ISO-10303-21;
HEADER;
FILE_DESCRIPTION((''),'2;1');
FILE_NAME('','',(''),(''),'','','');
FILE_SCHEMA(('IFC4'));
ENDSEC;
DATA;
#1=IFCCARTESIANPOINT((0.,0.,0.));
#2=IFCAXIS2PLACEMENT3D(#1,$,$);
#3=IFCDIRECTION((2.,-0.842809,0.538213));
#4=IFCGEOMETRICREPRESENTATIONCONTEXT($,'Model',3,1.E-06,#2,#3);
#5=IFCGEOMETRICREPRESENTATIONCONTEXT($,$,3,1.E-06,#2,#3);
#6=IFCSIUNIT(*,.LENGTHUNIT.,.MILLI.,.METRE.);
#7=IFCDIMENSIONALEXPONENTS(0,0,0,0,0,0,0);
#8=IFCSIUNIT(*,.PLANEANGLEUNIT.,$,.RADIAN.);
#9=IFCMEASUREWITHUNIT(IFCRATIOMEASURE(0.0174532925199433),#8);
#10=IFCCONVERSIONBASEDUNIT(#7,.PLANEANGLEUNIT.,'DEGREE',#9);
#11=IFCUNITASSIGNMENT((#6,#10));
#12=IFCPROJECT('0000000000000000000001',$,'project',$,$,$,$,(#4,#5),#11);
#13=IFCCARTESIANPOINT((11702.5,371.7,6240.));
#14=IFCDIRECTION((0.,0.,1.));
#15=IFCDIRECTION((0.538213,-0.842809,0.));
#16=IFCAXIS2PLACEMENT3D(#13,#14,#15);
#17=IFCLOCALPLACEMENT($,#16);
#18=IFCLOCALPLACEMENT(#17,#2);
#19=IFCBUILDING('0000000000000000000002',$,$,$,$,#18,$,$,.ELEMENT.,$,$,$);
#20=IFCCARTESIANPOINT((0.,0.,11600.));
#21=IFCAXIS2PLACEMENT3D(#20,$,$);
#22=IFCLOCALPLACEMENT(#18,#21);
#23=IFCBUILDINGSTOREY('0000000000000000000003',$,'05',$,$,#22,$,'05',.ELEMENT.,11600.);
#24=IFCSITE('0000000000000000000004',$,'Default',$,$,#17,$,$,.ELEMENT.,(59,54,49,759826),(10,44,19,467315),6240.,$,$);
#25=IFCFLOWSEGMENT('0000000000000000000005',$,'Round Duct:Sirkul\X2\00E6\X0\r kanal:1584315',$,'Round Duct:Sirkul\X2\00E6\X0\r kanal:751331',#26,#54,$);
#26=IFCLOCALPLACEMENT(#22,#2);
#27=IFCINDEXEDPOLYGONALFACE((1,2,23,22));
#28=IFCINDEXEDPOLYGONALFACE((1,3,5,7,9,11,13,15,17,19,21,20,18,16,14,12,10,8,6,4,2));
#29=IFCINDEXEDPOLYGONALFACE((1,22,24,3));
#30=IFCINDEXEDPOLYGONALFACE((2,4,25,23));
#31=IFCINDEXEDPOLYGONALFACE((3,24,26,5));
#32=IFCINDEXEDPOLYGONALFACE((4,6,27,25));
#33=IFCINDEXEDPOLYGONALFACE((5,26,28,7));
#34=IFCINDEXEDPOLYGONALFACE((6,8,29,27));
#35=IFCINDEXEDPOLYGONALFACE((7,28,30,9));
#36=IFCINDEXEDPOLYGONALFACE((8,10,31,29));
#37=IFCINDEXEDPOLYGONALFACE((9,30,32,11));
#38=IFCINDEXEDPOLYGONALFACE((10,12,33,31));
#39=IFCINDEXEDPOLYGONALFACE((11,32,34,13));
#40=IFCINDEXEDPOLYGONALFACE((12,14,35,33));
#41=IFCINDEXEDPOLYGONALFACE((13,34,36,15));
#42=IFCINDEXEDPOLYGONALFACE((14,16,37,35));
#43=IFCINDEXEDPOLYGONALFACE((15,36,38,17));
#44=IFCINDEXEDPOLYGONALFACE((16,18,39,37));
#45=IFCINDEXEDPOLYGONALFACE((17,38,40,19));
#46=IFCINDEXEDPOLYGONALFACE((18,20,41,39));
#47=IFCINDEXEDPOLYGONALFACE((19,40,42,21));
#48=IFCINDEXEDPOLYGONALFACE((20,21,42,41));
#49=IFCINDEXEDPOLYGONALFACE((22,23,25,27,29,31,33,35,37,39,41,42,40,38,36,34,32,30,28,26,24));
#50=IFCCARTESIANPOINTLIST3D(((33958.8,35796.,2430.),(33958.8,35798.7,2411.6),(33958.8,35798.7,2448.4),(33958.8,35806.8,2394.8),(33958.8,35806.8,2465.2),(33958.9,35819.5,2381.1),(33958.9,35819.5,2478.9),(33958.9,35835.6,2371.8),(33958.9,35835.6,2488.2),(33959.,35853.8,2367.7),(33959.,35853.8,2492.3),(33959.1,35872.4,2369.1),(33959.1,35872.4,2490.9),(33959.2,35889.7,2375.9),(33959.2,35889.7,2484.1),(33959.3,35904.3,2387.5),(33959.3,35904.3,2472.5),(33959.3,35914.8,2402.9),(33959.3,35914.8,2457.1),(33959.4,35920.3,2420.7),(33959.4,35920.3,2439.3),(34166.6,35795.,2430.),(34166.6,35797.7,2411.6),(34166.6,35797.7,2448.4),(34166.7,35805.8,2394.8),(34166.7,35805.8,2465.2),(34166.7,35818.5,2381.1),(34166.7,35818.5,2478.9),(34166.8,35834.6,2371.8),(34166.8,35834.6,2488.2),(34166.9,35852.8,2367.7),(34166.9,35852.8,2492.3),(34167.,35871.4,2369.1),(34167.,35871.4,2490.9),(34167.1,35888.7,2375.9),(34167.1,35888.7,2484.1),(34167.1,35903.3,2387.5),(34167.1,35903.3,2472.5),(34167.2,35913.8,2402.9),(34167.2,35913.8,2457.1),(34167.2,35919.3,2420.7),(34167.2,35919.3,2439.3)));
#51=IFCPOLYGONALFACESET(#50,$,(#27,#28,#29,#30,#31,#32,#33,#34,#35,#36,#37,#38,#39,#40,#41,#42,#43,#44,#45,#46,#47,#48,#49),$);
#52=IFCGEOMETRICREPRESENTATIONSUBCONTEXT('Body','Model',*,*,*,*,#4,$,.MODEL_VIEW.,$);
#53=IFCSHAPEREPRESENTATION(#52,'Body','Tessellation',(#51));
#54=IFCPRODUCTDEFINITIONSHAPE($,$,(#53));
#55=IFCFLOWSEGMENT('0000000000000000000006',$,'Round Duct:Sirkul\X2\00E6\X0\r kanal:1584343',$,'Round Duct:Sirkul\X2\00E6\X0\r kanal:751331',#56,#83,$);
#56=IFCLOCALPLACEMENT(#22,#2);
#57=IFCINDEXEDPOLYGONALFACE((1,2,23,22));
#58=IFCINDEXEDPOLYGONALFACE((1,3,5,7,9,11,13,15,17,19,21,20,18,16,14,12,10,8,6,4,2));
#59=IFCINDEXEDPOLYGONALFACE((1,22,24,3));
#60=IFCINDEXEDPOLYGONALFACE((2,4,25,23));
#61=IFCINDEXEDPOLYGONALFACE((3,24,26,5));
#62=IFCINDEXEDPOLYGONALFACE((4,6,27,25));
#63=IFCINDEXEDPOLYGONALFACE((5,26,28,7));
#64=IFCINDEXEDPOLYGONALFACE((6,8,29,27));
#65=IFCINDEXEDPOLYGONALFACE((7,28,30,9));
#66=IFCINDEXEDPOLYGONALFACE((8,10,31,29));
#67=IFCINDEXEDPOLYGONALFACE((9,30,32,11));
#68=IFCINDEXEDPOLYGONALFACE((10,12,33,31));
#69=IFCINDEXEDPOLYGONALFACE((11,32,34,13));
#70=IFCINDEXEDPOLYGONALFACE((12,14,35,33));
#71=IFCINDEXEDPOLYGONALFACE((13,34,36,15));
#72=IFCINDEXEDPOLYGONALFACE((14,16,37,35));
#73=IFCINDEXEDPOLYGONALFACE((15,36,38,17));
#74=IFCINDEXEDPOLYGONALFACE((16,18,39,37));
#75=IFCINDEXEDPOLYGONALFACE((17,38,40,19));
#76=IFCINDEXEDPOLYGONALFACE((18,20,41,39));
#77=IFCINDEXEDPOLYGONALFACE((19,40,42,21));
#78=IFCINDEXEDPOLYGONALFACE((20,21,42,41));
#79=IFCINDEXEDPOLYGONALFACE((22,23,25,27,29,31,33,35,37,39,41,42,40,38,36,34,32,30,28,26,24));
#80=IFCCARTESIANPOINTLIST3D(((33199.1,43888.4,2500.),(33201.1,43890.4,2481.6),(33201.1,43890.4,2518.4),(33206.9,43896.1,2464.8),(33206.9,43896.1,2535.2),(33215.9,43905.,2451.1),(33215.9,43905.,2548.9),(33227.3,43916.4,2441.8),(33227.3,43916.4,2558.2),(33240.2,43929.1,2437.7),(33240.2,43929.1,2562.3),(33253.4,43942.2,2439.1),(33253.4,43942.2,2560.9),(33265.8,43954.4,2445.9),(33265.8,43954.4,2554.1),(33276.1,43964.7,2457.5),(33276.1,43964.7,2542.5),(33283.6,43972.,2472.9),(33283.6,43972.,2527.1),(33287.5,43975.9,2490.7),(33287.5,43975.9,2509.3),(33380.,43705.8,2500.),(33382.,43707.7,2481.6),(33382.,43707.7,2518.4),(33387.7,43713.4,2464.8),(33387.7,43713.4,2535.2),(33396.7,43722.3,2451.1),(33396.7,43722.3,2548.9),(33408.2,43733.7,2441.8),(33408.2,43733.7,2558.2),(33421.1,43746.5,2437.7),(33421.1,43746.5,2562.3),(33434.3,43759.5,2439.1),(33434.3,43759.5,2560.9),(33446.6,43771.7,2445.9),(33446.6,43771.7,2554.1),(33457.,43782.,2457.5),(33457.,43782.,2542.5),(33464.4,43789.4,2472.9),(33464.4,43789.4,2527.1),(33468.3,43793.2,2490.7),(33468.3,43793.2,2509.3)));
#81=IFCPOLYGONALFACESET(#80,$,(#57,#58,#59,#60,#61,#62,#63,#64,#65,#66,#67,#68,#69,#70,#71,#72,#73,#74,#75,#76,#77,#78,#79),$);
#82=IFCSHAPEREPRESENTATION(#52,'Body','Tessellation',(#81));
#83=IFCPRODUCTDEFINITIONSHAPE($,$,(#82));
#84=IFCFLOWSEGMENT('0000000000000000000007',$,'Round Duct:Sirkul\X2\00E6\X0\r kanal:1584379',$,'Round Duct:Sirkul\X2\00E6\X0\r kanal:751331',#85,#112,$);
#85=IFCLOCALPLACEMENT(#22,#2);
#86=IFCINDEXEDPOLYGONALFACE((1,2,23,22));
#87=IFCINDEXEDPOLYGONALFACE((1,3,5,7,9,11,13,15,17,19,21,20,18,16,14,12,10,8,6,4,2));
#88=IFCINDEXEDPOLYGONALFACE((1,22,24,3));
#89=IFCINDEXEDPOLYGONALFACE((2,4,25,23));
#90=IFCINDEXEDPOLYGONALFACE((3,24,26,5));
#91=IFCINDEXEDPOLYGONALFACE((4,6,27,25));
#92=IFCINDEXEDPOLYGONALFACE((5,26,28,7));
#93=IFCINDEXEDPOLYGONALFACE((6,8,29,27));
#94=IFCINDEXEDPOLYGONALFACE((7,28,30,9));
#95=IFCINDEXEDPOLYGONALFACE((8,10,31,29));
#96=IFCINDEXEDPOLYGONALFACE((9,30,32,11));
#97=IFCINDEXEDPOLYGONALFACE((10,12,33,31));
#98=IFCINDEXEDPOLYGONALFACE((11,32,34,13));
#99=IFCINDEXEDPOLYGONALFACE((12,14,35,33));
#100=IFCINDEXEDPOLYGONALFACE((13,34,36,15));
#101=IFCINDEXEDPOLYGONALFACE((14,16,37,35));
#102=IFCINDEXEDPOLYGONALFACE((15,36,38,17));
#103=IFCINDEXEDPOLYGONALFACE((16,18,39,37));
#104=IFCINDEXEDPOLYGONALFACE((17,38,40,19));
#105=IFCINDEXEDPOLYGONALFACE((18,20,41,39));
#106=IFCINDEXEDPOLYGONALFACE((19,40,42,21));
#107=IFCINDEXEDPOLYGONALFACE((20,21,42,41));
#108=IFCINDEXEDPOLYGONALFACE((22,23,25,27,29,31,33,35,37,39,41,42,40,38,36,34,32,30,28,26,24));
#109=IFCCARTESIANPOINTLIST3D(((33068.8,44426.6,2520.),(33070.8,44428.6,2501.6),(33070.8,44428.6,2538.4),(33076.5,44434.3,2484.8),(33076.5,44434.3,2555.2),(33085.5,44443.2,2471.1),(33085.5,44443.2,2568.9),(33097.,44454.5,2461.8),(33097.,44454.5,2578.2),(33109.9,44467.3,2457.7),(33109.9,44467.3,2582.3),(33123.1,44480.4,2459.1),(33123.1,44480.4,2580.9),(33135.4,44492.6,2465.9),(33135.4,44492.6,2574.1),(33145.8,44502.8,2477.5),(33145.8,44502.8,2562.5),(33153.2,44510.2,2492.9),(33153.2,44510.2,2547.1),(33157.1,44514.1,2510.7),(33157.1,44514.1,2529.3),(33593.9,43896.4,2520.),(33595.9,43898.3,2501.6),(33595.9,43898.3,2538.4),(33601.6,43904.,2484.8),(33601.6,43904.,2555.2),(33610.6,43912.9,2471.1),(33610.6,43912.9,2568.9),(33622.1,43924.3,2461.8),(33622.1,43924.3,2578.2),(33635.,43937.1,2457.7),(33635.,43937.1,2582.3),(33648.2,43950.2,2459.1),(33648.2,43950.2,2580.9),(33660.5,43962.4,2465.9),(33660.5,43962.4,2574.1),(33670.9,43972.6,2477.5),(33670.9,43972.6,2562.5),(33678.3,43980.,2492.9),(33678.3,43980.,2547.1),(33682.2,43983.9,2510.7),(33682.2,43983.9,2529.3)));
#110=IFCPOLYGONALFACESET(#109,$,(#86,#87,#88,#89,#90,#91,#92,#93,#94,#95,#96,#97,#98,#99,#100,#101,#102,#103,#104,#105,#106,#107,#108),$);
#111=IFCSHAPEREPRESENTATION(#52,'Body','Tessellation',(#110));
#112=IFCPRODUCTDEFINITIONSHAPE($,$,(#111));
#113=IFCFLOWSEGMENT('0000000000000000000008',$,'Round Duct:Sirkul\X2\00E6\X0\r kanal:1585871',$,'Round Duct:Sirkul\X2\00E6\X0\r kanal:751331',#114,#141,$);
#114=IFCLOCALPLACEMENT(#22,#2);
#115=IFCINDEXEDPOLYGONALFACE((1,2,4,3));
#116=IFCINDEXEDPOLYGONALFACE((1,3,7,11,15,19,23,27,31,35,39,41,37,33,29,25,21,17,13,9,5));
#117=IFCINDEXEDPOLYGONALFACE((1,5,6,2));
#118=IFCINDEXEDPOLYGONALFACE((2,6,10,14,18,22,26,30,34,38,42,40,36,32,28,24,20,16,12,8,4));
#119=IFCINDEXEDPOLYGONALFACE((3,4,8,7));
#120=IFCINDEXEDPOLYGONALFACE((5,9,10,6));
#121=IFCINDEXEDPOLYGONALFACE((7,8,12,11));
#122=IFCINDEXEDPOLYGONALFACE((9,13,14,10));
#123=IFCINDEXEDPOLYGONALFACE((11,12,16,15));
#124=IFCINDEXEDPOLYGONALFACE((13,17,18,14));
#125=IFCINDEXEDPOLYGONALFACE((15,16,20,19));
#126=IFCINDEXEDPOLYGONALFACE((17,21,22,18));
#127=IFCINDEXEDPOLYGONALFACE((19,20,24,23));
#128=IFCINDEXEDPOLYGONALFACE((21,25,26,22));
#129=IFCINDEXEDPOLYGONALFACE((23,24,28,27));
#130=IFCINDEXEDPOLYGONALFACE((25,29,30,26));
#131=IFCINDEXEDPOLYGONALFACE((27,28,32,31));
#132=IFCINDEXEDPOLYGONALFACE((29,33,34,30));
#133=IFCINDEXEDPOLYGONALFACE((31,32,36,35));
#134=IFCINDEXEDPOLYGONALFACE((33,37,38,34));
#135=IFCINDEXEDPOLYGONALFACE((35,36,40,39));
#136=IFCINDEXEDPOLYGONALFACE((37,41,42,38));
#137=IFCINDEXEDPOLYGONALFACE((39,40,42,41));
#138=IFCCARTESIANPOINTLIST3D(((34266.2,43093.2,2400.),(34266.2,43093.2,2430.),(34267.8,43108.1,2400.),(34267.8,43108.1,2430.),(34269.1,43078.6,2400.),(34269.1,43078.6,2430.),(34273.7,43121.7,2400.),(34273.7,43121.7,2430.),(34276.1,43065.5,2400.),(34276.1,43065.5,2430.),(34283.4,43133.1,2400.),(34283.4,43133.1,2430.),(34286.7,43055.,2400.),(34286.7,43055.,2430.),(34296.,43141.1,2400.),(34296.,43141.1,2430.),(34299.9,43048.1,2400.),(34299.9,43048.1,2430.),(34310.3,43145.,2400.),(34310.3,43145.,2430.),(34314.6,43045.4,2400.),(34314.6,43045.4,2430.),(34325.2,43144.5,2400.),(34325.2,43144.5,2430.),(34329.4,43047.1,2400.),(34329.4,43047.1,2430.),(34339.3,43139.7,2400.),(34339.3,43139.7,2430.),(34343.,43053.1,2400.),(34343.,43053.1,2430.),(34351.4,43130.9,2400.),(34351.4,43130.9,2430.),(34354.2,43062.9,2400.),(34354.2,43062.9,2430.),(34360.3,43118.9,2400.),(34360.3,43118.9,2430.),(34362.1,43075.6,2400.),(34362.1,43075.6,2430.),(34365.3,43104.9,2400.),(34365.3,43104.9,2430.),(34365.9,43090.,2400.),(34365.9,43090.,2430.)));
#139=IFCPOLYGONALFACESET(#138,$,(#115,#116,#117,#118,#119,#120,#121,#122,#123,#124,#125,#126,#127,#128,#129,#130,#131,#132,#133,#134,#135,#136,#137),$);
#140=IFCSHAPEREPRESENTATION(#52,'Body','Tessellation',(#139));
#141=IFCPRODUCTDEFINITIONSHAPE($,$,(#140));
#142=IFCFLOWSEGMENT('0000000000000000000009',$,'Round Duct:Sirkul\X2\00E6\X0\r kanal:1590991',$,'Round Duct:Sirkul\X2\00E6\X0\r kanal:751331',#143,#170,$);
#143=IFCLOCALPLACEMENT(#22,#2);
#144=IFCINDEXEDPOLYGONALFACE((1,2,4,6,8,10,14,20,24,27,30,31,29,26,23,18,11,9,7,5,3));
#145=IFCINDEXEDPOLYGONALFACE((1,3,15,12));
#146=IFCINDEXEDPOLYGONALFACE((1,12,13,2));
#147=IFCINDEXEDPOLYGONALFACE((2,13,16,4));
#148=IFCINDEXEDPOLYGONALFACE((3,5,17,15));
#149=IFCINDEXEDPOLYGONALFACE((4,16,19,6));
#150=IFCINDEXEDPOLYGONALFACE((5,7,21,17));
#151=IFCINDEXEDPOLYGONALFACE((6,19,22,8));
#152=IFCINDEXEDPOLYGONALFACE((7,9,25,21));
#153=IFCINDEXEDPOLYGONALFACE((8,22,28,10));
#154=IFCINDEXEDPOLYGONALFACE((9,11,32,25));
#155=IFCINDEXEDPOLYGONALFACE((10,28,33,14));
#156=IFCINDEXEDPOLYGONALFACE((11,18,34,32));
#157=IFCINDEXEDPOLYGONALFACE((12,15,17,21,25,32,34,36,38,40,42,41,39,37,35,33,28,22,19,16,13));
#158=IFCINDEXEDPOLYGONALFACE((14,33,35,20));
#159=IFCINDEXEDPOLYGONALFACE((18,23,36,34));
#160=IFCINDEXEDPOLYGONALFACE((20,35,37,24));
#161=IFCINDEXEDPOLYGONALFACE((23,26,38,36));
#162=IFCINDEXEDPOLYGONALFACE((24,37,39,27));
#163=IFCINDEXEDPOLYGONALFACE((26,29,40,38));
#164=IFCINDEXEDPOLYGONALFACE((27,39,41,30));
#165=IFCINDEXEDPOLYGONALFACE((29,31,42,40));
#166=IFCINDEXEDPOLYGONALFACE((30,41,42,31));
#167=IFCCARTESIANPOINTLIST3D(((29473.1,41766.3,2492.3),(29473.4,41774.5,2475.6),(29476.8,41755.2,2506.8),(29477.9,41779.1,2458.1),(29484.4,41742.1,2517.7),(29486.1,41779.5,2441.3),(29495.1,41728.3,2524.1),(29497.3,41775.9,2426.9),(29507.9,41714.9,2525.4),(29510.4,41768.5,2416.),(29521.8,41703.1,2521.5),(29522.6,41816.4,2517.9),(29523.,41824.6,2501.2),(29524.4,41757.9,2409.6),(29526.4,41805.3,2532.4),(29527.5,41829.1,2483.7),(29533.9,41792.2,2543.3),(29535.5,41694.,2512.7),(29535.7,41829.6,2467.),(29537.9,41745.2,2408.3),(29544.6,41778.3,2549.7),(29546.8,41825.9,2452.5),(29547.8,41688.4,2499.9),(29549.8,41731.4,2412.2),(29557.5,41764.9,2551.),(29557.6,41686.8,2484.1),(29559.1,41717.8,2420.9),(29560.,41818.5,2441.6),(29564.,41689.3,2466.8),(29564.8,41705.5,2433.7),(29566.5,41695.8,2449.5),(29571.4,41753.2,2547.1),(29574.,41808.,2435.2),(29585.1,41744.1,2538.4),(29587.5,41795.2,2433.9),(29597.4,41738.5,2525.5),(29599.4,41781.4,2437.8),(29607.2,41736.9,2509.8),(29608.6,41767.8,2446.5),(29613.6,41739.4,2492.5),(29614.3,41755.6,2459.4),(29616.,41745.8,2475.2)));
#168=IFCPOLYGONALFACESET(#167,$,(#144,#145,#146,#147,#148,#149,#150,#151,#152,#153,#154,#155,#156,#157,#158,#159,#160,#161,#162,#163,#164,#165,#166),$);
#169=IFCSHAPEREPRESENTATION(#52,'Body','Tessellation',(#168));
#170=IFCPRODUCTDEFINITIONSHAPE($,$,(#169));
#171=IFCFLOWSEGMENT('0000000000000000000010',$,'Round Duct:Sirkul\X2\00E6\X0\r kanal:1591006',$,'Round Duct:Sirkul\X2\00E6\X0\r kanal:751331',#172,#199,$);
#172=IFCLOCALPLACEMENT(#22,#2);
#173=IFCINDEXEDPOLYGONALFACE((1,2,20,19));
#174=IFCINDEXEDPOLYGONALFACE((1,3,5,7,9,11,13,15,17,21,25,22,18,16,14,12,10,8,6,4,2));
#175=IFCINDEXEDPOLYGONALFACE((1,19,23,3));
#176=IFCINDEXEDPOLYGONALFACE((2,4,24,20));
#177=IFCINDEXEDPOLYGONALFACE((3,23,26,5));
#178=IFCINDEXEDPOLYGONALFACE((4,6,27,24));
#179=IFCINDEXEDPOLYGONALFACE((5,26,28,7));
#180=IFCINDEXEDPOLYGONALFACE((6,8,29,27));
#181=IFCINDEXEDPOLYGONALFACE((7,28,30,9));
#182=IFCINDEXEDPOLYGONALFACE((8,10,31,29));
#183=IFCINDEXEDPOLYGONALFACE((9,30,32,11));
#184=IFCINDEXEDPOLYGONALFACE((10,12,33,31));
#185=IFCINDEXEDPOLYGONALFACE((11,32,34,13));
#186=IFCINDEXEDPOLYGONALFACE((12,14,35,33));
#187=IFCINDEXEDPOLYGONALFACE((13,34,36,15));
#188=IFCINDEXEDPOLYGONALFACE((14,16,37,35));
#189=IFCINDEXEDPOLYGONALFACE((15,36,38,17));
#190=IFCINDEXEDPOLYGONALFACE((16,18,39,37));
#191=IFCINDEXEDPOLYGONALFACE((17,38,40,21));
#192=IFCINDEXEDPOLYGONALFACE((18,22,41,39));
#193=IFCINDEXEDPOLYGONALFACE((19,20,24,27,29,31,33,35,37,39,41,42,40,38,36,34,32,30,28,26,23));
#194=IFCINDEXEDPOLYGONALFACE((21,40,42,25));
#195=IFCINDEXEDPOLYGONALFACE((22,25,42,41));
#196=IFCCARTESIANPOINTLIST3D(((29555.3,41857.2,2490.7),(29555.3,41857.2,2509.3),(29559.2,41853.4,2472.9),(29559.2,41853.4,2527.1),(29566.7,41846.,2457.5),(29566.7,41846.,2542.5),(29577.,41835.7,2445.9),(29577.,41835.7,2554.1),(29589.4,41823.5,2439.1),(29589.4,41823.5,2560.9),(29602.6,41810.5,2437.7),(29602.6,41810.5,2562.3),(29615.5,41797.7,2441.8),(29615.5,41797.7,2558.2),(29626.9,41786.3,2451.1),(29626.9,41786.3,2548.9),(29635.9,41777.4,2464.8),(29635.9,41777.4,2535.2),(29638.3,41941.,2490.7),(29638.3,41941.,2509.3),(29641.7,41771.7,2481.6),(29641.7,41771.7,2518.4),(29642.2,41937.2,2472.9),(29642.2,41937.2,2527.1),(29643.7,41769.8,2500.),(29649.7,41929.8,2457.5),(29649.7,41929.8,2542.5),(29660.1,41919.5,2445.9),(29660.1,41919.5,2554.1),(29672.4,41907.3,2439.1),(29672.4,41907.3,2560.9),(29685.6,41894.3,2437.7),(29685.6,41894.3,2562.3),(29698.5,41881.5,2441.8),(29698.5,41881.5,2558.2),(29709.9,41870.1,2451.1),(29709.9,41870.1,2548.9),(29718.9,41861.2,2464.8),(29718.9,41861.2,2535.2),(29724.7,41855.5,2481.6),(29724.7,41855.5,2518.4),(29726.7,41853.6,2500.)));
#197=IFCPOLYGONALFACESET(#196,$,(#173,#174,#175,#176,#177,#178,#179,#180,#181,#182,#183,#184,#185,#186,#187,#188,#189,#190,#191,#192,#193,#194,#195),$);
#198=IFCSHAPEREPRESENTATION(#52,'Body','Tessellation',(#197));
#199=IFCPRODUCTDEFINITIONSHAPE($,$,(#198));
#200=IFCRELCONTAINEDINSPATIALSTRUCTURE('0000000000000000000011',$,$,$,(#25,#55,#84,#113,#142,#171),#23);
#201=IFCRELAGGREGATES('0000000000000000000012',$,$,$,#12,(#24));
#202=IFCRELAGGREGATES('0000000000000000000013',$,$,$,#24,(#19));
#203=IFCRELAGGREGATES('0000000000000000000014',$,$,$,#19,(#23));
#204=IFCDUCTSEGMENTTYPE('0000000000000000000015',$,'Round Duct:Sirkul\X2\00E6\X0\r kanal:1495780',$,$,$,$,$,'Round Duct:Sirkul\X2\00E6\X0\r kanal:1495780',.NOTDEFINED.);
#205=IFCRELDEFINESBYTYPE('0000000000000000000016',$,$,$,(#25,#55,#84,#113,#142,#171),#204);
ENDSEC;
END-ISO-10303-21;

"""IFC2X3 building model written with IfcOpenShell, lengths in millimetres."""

from ifc_helpers import new_model, entity, si_unit, converted_unit, direction, frame, frame_2d, origin, origin_2d_with_axis, place, context, subcontext, project, spatial, circle, extrude, type_object, element, save


model = new_model("IFC2X3")

# Units and contexts
model_context = context("Model", 3, precision=1e-06, world=origin(), true_north=direction((2.0, -0.842809, 0.538213)))
context_of_model = context(None, 3, precision=1e-06, world=origin(), true_north=direction((2.0, -0.842809, 0.538213)))
body_context = subcontext(model_context, "Body", "Model", "MODEL_VIEW")
ifc_project = project(units=[si_unit("LENGTHUNIT", "METRE", prefix="MILLI"), converted_unit("PLANEANGLEUNIT", "DEGREE", entity("IfcRatioMeasure", 0.0174532925199433), si_unit("PLANEANGLEUNIT", "RADIAN"), dimensions=[0, 0, 0, 0, 0, 0, 0])], contexts=[model_context, context_of_model])

# Site, building, storey
site_placement = place(None, frame((11702.5, 371.7, 6240.0), z_axis=(0.0, 0.0, 1.0), x_axis=(0.538213, -0.842809, 0.0)))
site = spatial("IfcSite", under=ifc_project, at=site_placement, Name="Default", CompositionType="ELEMENT", RefLatitude=(59, 54, 49, 759826), RefLongitude=(10, 44, 19, 467315), RefElevation=6240.0)
building_placement = place(site_placement, origin())
building = spatial("IfcBuilding", under=site, at=building_placement, CompositionType="ELEMENT")
storey_placement = place(building_placement, frame((0.0, 0.0, 11600.0)))
storey = spatial("IfcBuildingStorey", under=building, at=storey_placement, Name="05", LongName="05", CompositionType="ELEMENT", Elevation=11600.0)

# Flow segments
duct_segment_type = type_object("IfcDuctSegmentType", Name="Round Duct:Sirkulær kanal:1495780", ElementType="Round Duct:Sirkulær kanal:1495780", PredefinedType="NOTDEFINED")
flow_segment_1_placement = place(storey_placement, origin())
element("IfcFlowSegment", 1, at=flow_segment_1_placement, inside=storey, type_object=duct_segment_type, Name="Round Duct:Sirkulær kanal:1584315", ObjectType="Round Duct:Sirkulær kanal:751331", context=body_context, shape_type="SweptSolid", body=[
    extrude(circle(Radius=62.5, at=frame_2d((0.0, 0.0), x_axis=(1.0, 0.0))), frame((34166.9, 35857.5, 2430.0), z_axis=(-0.999988, 0.004887, 0.0), x_axis=(-0.004887, -0.999988, 0.0)), (0.0, 0.0, 1.0), 207.9),
])
flow_segment_2_placement = place(storey_placement, origin())
element("IfcFlowSegment", 2, at=flow_segment_2_placement, inside=storey, type_object=duct_segment_type, Name="Round Duct:Sirkulær kanal:1584343", ObjectType="Round Duct:Sirkulær kanal:751331", context=body_context, shape_type="SweptSolid", body=[
    extrude(circle(Radius=62.5, at=origin_2d_with_axis()), frame((33424.4, 43749.8, 2500.0), z_axis=(-0.703643, 0.710554, 0.0), x_axis=(-0.710554, -0.703643, 0.0)), (0.0, 0.0, 1.0), 257.1),
])
flow_segment_3_placement = place(storey_placement, origin())
element("IfcFlowSegment", 3, at=flow_segment_3_placement, inside=storey, type_object=duct_segment_type, Name="Round Duct:Sirkulær kanal:1584379", ObjectType="Round Duct:Sirkulær kanal:751331", context=body_context, shape_type="SweptSolid", body=[
    extrude(circle(Radius=62.5, at=frame_2d((0.0, 0.0), x_axis=(1.0, 0.0))), frame((33113.2, 44470.6, 2520.0), z_axis=(0.703643, -0.710554, 0.0), x_axis=(-0.710554, -0.703643, 0.0)), (0.0, 0.0, 1.0), 746.2),
])
flow_segment_4_placement = place(storey_placement, origin())
element("IfcFlowSegment", 4, at=flow_segment_4_placement, inside=storey, type_object=duct_segment_type, Name="Round Duct:Sirkulær kanal:1585871", ObjectType="Round Duct:Sirkulær kanal:751331", context=body_context, shape_type="SweptSolid", body=[
    extrude(circle(Radius=50.0, at=frame_2d((0.0, 0.0), x_axis=(1.0, 0.0))), frame((34316.2, 43095.3, 2400.0), z_axis=(0.0, 0.0, 1.0), x_axis=(0.703643, 0.710554, 0.0)), (0.0, 0.0, 1.0), 30.0),
])
flow_segment_5_placement = place(storey_placement, origin())
element("IfcFlowSegment", 5, at=flow_segment_5_placement, inside=storey, type_object=duct_segment_type, Name="Round Duct:Sirkulær kanal:1590991", ObjectType="Round Duct:Sirkulær kanal:751331", context=body_context, shape_type="SweptSolid", body=[
    extrude(circle(Radius=62.5, at=frame_2d((0.0, 0.0), x_axis=(1.0, 0.0))), frame((29519.6, 41733.3, 2466.8), z_axis=(0.661208, 0.667702, 0.34202), x_axis=(0.710554, -0.703643, 0.0)), (0.0, 0.0, 1.0), 75.0),
])
flow_segment_6_placement = place(storey_placement, origin())
element("IfcFlowSegment", 6, at=flow_segment_6_placement, inside=storey, type_object=duct_segment_type, Name="Round Duct:Sirkulær kanal:1591006", ObjectType="Round Duct:Sirkulær kanal:751331", context=body_context, shape_type="SweptSolid", body=[
    extrude(circle(Radius=62.5, at=origin_2d_with_axis()), frame((29599.3, 41813.7, 2500.0), z_axis=(0.703643, 0.710554, 0.0), x_axis=(0.710554, -0.703643, 0.0)), (0.0, 0.0, 1.0), 118.0),
])

save(model, "model.ifc")
